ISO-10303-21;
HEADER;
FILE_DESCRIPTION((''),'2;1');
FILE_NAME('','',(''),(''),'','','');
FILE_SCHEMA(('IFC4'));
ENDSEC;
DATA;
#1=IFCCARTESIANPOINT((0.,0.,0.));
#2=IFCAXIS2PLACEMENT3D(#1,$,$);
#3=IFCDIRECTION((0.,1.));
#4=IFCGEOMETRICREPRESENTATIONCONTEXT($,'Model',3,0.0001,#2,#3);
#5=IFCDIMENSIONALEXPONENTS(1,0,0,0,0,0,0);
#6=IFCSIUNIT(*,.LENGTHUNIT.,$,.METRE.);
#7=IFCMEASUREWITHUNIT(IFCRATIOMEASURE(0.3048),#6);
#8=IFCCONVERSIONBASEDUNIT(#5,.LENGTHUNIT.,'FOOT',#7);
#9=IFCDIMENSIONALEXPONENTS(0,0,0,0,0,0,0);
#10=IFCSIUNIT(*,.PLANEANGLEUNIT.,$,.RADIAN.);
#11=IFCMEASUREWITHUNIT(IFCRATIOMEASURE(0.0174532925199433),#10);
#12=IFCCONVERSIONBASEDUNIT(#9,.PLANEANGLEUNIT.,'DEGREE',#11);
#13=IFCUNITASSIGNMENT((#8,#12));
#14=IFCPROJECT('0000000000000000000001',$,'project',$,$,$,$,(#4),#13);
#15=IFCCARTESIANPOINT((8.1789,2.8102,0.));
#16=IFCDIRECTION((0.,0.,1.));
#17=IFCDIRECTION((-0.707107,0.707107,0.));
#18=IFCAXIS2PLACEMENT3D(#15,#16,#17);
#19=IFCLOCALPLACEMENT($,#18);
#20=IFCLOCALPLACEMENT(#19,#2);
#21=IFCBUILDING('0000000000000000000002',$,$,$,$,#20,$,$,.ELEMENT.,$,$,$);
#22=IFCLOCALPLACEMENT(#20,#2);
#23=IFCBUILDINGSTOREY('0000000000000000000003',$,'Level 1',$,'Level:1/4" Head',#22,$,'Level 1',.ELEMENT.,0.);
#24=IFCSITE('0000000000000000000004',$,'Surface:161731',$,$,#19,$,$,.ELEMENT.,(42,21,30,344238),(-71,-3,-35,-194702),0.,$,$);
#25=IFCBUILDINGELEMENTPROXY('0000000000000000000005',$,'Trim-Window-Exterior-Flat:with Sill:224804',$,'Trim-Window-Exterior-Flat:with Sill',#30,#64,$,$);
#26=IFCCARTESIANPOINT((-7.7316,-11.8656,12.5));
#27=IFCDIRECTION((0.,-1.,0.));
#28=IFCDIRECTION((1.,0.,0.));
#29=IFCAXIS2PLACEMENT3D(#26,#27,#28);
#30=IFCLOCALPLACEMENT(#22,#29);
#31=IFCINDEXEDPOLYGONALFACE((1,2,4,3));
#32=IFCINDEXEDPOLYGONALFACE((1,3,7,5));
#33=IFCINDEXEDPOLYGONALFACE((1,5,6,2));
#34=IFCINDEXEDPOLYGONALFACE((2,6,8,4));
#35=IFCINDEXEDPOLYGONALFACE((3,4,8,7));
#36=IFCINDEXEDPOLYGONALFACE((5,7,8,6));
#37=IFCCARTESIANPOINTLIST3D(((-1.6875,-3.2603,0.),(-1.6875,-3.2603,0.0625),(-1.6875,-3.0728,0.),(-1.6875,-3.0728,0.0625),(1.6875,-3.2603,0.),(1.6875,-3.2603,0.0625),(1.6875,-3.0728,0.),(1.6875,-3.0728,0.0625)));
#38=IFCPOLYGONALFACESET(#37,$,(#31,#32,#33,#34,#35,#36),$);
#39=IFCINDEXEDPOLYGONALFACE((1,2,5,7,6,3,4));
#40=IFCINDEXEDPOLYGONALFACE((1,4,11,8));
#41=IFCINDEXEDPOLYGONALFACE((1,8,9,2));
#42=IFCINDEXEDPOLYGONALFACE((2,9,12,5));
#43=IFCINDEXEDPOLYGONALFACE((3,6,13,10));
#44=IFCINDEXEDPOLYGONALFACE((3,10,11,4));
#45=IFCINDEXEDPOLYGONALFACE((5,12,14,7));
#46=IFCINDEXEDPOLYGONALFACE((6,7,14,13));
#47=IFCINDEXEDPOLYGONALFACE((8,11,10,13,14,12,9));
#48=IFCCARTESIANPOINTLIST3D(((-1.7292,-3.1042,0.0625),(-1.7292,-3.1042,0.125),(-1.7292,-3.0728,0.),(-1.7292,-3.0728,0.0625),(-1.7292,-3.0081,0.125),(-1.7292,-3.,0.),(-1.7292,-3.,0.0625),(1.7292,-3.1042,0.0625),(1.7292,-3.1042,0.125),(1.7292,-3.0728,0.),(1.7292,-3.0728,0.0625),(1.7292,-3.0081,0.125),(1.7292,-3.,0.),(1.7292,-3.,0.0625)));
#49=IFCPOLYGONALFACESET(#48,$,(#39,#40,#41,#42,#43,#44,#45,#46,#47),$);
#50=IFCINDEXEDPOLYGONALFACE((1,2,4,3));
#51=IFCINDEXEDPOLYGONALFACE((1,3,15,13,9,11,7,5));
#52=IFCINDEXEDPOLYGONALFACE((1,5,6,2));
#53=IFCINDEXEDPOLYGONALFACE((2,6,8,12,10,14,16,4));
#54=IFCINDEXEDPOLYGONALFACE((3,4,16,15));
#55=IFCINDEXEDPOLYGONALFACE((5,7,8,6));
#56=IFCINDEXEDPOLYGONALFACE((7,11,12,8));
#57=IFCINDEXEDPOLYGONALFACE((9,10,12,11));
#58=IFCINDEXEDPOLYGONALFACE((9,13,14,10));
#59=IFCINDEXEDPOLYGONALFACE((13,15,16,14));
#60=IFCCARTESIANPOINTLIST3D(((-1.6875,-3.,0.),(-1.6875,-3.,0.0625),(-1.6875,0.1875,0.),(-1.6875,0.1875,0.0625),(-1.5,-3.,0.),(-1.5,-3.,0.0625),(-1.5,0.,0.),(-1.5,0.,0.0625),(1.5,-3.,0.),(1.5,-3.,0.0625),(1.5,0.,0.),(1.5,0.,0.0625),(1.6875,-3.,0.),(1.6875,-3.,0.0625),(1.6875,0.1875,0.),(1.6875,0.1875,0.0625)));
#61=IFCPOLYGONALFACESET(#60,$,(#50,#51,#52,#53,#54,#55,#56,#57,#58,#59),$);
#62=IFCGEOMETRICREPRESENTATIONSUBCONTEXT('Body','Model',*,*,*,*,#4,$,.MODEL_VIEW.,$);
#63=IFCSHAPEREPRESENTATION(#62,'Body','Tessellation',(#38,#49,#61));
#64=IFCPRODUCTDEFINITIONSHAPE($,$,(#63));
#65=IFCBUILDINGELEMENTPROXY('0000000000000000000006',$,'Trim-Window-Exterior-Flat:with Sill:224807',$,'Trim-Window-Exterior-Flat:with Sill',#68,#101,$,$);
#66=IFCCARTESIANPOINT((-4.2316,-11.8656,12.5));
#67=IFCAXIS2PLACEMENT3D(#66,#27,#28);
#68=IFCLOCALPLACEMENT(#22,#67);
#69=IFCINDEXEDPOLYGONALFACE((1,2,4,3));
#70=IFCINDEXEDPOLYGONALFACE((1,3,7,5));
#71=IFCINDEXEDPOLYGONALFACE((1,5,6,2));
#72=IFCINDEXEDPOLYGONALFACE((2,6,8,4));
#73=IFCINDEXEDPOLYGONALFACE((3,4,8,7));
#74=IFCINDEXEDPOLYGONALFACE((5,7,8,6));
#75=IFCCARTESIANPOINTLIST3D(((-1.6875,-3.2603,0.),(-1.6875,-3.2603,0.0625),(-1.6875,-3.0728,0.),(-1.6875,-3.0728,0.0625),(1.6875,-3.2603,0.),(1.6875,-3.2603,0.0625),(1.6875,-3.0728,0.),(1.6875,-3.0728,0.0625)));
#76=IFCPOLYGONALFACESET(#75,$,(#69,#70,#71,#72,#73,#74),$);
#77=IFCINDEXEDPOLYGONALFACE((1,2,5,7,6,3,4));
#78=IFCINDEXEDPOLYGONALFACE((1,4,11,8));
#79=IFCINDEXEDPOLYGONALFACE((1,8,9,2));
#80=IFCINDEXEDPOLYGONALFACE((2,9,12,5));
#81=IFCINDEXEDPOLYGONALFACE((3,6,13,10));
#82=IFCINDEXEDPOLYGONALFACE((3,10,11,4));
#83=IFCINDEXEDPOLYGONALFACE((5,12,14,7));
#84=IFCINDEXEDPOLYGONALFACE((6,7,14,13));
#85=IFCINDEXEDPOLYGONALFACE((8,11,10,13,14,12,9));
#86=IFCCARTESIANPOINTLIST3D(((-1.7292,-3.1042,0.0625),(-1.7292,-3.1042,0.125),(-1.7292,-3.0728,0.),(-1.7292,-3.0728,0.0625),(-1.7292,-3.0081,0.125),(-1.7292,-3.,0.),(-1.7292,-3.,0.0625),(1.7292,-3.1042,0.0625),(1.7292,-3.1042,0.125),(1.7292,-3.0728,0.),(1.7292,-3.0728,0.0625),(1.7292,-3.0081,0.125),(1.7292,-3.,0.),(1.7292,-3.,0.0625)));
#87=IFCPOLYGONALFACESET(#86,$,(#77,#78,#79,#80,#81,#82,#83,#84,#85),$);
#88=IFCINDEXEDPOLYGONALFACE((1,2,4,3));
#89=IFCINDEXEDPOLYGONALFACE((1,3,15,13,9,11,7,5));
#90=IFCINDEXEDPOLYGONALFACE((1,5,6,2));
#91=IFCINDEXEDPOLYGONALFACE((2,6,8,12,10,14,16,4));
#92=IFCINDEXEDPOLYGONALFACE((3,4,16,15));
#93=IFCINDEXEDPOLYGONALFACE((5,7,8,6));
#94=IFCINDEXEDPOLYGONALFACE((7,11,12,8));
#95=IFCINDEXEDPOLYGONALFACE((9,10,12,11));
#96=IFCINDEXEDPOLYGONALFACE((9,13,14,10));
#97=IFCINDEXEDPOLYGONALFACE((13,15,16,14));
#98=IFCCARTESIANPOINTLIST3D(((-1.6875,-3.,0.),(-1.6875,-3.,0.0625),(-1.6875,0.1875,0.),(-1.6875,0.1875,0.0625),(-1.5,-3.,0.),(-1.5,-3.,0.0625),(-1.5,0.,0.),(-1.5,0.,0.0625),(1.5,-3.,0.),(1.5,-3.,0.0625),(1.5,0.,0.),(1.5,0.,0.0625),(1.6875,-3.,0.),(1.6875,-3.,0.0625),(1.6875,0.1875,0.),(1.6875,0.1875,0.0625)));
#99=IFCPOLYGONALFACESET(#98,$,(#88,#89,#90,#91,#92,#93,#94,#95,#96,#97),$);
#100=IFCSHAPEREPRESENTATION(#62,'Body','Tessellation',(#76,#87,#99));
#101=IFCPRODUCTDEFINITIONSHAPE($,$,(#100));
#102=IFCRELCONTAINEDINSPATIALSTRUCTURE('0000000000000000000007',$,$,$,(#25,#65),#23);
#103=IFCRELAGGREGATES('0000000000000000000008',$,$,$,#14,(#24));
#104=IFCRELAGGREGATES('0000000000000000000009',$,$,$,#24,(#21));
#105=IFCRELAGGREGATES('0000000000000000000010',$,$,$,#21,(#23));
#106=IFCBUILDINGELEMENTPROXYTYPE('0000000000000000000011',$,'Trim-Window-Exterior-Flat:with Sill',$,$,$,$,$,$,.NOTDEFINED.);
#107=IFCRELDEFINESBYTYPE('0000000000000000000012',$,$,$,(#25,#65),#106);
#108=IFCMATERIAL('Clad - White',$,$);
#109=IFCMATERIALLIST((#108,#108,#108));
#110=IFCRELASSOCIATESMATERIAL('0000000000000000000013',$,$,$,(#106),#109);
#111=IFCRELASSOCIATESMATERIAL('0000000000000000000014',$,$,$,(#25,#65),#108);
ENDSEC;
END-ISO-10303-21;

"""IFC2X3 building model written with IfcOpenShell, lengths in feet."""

from ifc_helpers import new_model, entity, si_unit, converted_unit, direction, frame, frame_2d, origin, place, context, subcontext, project, spatial, polyline, rectangle, outline, extrude, source, transform, mapped, material, material_list, type_object, type_shapes, element, save


model = new_model("IFC2X3")

# Units and contexts
model_context = context("Model", 3, precision=0.0001, world=origin(), true_north=direction((0.0, 1.0)))
body_context = subcontext(model_context, "Body", "Model", "MODEL_VIEW")
ifc_project = project(units=[converted_unit("LENGTHUNIT", "FOOT", entity("IfcRatioMeasure", 0.3048), si_unit("LENGTHUNIT", "METRE"), dimensions=[1, 0, 0, 0, 0, 0, 0]), converted_unit("PLANEANGLEUNIT", "DEGREE", entity("IfcRatioMeasure", 0.0174532925199433), si_unit("PLANEANGLEUNIT", "RADIAN"), dimensions=[0, 0, 0, 0, 0, 0, 0])], contexts=[model_context])

# Site, building, storey
site_placement = place(None, frame((8.1789, 2.8102, 0.0), z_axis=(0.0, 0.0, 1.0), x_axis=(-0.707107, 0.707107, 0.0)))
site = spatial("IfcSite", under=ifc_project, at=site_placement, Name="Surface:161731", CompositionType="ELEMENT", RefLatitude=(42, 21, 30, 344238), RefLongitude=(-71, -3, -35, -194702), RefElevation=0.0)
building_placement = place(site_placement, origin())
building = spatial("IfcBuilding", under=site, at=building_placement, CompositionType="ELEMENT")
storey_placement = place(building_placement, origin())
storey = spatial("IfcBuildingStorey", under=building, at=storey_placement, Name="Level 1", ObjectType="Level:1/4\" Head", LongName="Level 1", CompositionType="ELEMENT", Elevation=0.0)

# Building element proxies
ifc_material_1 = material(Name="Clad - White")
ifc_material_list_1 = material_list([ifc_material_1, ifc_material_1, ifc_material_1])
building_element_proxy_type_1 = type_object("IfcBuildingElementProxyType", Name="Trim-Window-Exterior-Flat:with Sill", PredefinedType="NOTDEFINED", material=ifc_material_list_1)
shared_shape_1 = source(origin(), body_context, "Body", "SweptSolid", [
    extrude(rectangle(XDim=3.375, YDim=0.1875, at=frame_2d((0.0, 0.0), x_axis=(1.0, 0.0))), frame((0.0, -3.1665, 0.0), z_axis=(0.0, 0.0, 1.0), x_axis=(-1.0, 0.0, 0.0)), (0.0, 0.0, 1.0), 0.0625),
    extrude(outline(polyline([(-0.0625, -0.0525), (0.0, -0.0525), (0.0, -0.0211), (0.0625, -0.0211), (0.0625, 0.0517), (0.0, 0.0517), (-0.0625, 0.0436), (-0.0625, -0.0525)])), frame((-1.7292, -3.0517, 0.0625), z_axis=(1.0, 0.0, 0.0), x_axis=(0.0, 0.0, -1.0)), (0.0, 0.0, 1.0), 3.4583),
    extrude(outline(polyline([(-1.6406, -1.6875), (1.5469, -1.6875), (1.5469, -1.5), (-1.4531, -1.5), (-1.4531, 1.5), (1.5469, 1.5), (1.5469, 1.6875), (-1.6406, 1.6875), (-1.6406, -1.6875)])), frame((0.0, -1.4531, 0.0), z_axis=(0.0, 0.0, 1.0), x_axis=(0.0, -1.0, 0.0)), (0.0, 0.0, 1.0), 0.0625),
])
type_shapes(building_element_proxy_type_1, [shared_shape_1])
for number, where, z_axis, x_axis, name in (
    (1, (-7.7316, -11.8656, 12.5), (0.0, -1.0, 0.0), (1.0, 0.0, 0.0), "Trim-Window-Exterior-Flat:with Sill:224804"),
    (2, (-4.2316, -11.8656, 12.5), (0.0, -1.0, 0.0), (1.0, 0.0, 0.0), "Trim-Window-Exterior-Flat:with Sill:224807"),
):
    element("IfcBuildingElementProxy", number, at=place(storey_placement, frame(where, z_axis=z_axis, x_axis=x_axis)), inside=storey, type_object=building_element_proxy_type_1, material=ifc_material_1, Name=name, ObjectType="Trim-Window-Exterior-Flat:with Sill", context=body_context, shape_type="MappedRepresentation", body=[
        mapped(shared_shape_1, transform((0.0, 0.0, 0.0), scale=1.0)),
    ])

save(model, "model.ifc")
